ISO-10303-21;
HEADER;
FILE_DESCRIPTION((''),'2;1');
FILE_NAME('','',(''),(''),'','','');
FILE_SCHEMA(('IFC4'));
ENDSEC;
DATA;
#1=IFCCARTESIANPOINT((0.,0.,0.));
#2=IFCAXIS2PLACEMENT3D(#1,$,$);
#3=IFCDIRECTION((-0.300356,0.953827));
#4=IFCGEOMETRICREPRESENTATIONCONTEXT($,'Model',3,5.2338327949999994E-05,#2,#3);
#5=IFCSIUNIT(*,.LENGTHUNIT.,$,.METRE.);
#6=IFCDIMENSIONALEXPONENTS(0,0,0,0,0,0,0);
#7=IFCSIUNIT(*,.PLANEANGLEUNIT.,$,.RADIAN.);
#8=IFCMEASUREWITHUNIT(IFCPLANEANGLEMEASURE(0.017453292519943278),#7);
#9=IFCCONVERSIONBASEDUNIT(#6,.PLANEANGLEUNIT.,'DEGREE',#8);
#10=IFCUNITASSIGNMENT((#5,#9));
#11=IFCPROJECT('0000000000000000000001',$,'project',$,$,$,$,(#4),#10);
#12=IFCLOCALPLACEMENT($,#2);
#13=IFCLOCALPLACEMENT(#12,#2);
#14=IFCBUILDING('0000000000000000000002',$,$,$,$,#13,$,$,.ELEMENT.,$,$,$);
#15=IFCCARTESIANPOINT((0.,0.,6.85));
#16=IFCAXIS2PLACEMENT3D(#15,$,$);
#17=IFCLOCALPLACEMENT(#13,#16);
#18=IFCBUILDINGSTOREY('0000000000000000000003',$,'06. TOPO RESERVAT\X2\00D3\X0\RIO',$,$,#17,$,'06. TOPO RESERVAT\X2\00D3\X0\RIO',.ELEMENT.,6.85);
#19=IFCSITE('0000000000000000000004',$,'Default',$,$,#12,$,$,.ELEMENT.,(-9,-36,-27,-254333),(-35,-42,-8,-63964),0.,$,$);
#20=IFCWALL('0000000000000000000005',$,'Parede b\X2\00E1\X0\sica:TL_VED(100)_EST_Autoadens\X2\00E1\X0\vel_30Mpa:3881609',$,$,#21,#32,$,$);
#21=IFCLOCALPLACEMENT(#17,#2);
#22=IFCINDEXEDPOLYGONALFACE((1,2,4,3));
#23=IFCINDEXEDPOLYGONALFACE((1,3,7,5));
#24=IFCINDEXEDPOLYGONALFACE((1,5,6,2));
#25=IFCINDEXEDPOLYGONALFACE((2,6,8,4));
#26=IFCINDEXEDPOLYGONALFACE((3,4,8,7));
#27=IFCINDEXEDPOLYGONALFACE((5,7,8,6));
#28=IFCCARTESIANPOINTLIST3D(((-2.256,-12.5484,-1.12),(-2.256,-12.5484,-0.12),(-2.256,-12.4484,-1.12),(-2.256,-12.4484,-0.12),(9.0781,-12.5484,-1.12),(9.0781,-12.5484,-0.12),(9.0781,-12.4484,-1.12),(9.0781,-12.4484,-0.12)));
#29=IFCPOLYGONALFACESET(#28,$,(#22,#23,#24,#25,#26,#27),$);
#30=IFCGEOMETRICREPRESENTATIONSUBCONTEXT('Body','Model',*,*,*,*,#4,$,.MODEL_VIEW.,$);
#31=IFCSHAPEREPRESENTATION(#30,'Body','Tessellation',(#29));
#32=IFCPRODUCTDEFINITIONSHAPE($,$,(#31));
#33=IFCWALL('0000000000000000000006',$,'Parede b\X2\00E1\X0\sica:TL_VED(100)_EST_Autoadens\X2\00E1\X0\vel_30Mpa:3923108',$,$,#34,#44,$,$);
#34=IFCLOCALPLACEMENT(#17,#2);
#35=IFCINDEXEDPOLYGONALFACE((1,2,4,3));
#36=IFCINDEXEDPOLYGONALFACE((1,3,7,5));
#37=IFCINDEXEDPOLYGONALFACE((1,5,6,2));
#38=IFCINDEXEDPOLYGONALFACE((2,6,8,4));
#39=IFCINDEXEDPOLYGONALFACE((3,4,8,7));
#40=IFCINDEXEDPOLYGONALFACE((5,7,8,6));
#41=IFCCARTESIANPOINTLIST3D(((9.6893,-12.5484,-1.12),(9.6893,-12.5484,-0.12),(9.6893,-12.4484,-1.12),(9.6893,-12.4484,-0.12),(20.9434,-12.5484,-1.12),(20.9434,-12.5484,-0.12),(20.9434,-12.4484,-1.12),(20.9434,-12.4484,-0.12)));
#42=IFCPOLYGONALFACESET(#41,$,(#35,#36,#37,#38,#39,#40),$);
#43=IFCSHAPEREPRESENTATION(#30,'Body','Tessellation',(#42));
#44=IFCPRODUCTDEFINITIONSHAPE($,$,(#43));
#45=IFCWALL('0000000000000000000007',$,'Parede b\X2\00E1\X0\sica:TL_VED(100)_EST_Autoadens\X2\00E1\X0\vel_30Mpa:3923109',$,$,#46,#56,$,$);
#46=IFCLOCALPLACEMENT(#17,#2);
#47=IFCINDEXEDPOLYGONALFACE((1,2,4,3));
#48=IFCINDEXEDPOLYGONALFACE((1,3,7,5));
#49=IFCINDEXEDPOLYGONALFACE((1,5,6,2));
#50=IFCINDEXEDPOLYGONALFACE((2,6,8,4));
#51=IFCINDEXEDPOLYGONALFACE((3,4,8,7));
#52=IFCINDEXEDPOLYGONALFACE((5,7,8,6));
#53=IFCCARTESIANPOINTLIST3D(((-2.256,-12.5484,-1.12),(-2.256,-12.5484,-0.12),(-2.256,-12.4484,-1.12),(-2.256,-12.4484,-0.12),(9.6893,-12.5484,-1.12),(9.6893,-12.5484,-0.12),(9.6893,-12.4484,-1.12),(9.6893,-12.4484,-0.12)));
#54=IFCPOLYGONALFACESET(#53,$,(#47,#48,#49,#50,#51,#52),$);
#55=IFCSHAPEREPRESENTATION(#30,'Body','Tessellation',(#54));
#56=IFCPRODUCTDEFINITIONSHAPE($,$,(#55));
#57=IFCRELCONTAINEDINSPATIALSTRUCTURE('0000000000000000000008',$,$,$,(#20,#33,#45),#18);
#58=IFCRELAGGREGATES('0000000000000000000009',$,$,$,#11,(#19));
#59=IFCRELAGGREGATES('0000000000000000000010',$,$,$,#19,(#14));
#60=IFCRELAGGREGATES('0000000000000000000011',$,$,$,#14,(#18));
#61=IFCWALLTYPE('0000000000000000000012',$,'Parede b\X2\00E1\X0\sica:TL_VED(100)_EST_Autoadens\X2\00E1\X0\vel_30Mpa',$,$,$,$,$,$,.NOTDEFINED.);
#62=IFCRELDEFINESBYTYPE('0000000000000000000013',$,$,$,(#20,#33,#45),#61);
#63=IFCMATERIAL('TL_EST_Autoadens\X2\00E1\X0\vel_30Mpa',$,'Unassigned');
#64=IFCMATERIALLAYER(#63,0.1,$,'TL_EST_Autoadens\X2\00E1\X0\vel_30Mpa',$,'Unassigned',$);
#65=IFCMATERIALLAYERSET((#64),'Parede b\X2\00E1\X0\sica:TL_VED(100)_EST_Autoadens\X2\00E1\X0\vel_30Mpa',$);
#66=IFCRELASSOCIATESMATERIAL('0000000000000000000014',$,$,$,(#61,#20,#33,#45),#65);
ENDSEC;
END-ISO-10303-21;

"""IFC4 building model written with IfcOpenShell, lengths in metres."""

from ifc_helpers import new_model, entity, si_unit, converted_unit, direction, frame, frame_2d, origin, place, context, subcontext, project, spatial, rectangle, extrude, material, layer, layer_set, layer_usage, type_object, element, save


model = new_model("IFC4")

# Units and contexts
model_context = context("Model", 3, precision=5.2338327949999994e-05, world=origin(), true_north=direction((-0.300356, 0.953827)))
body_context = subcontext(model_context, "Body", "Model", "MODEL_VIEW")
ifc_project = project(units=[si_unit("LENGTHUNIT", "METRE"), converted_unit("PLANEANGLEUNIT", "DEGREE", entity("IfcPlaneAngleMeasure", 0.017453292519943278), si_unit("PLANEANGLEUNIT", "RADIAN"), dimensions=[0, 0, 0, 0, 0, 0, 0])], contexts=[model_context])

# Site, building, storey
site_placement = place(None, origin())
site = spatial("IfcSite", under=ifc_project, at=site_placement, Name="Default", CompositionType="ELEMENT", RefLatitude=(-9, -36, -27, -254333), RefLongitude=(-35, -42, -8, -63964), RefElevation=0.0)
building_placement = place(site_placement, origin())
building = spatial("IfcBuilding", under=site, at=building_placement, CompositionType="ELEMENT")
storey_placement = place(building_placement, frame((0.0, 0.0, 6.85)))
storey = spatial("IfcBuildingStorey", under=building, at=storey_placement, Name="06. TOPO RESERVATÓRIO", LongName="06. TOPO RESERVATÓRIO", CompositionType="ELEMENT", Elevation=6.85)

# Walls
ifc_material_1 = material(Name="TL_EST_Autoadensável_30Mpa", Category="Unassigned")
ifc_layer = layer(ifc_material_1, 0.1, Name="TL_EST_Autoadensável_30Mpa", Category="Unassigned")
ifc_layer_set = layer_set([ifc_layer], Name="Parede básica:TL_VED(100)_EST_Autoadensável_30Mpa")
ifc_layer_usage_1 = layer_usage(ifc_layer_set, "AXIS2", "NEGATIVE", 0.05)
wall_type = type_object("IfcWallType", Name="Parede básica:TL_VED(100)_EST_Autoadensável_30Mpa", PredefinedType="NOTDEFINED", material=ifc_layer_set)
wall_1_placement = place(storey_placement, frame((9.0781, -12.4984, -1.12), z_axis=(0.0, 0.0, 1.0), x_axis=(-1.0, 0.0, 0.0)))
element("IfcWall", 1, at=wall_1_placement, inside=storey, type_object=wall_type, material=ifc_layer_usage_1, Name="Parede básica:TL_VED(100)_EST_Autoadensável_30Mpa:3881609", context=body_context, shape_type="SweptSolid", body=[
    extrude(rectangle(XDim=11.3341, YDim=0.1, at=frame_2d((5.6671, 0.0), x_axis=(-1.0, 0.0))), origin(), (0.0, 0.0, 1.0), 1.0),
])
ifc_layer_usage_2 = layer_usage(ifc_layer_set, "AXIS2", "POSITIVE", -0.05)
wall_2_placement = place(storey_placement, frame((9.6893, -12.4984, -1.12)))
element("IfcWall", 2, at=wall_2_placement, inside=storey, type_object=wall_type, material=ifc_layer_usage_2, Name="Parede básica:TL_VED(100)_EST_Autoadensável_30Mpa:3923108", context=body_context, shape_type="SweptSolid", body=[
    extrude(rectangle(XDim=11.2541, YDim=0.1, at=frame_2d((5.6271, 0.0), x_axis=(-1.0, 0.0))), origin(), (0.0, 0.0, 1.0), 1.0),
])
ifc_layer_usage_3 = layer_usage(ifc_layer_set, "AXIS2", "NEGATIVE", 0.05)
wall_3_placement = place(storey_placement, frame((9.6893, -12.4984, -1.12), z_axis=(0.0, 0.0, 1.0), x_axis=(-1.0, 0.0, 0.0)))
element("IfcWall", 3, at=wall_3_placement, inside=storey, type_object=wall_type, material=ifc_layer_usage_3, Name="Parede básica:TL_VED(100)_EST_Autoadensável_30Mpa:3923109", context=body_context, shape_type="SweptSolid", body=[
    extrude(rectangle(XDim=11.9453, YDim=0.1, at=frame_2d((5.9726, 0.0), x_axis=(-1.0, 0.0))), origin(), (0.0, 0.0, 1.0), 1.0),
])

save(model, "model.ifc")
